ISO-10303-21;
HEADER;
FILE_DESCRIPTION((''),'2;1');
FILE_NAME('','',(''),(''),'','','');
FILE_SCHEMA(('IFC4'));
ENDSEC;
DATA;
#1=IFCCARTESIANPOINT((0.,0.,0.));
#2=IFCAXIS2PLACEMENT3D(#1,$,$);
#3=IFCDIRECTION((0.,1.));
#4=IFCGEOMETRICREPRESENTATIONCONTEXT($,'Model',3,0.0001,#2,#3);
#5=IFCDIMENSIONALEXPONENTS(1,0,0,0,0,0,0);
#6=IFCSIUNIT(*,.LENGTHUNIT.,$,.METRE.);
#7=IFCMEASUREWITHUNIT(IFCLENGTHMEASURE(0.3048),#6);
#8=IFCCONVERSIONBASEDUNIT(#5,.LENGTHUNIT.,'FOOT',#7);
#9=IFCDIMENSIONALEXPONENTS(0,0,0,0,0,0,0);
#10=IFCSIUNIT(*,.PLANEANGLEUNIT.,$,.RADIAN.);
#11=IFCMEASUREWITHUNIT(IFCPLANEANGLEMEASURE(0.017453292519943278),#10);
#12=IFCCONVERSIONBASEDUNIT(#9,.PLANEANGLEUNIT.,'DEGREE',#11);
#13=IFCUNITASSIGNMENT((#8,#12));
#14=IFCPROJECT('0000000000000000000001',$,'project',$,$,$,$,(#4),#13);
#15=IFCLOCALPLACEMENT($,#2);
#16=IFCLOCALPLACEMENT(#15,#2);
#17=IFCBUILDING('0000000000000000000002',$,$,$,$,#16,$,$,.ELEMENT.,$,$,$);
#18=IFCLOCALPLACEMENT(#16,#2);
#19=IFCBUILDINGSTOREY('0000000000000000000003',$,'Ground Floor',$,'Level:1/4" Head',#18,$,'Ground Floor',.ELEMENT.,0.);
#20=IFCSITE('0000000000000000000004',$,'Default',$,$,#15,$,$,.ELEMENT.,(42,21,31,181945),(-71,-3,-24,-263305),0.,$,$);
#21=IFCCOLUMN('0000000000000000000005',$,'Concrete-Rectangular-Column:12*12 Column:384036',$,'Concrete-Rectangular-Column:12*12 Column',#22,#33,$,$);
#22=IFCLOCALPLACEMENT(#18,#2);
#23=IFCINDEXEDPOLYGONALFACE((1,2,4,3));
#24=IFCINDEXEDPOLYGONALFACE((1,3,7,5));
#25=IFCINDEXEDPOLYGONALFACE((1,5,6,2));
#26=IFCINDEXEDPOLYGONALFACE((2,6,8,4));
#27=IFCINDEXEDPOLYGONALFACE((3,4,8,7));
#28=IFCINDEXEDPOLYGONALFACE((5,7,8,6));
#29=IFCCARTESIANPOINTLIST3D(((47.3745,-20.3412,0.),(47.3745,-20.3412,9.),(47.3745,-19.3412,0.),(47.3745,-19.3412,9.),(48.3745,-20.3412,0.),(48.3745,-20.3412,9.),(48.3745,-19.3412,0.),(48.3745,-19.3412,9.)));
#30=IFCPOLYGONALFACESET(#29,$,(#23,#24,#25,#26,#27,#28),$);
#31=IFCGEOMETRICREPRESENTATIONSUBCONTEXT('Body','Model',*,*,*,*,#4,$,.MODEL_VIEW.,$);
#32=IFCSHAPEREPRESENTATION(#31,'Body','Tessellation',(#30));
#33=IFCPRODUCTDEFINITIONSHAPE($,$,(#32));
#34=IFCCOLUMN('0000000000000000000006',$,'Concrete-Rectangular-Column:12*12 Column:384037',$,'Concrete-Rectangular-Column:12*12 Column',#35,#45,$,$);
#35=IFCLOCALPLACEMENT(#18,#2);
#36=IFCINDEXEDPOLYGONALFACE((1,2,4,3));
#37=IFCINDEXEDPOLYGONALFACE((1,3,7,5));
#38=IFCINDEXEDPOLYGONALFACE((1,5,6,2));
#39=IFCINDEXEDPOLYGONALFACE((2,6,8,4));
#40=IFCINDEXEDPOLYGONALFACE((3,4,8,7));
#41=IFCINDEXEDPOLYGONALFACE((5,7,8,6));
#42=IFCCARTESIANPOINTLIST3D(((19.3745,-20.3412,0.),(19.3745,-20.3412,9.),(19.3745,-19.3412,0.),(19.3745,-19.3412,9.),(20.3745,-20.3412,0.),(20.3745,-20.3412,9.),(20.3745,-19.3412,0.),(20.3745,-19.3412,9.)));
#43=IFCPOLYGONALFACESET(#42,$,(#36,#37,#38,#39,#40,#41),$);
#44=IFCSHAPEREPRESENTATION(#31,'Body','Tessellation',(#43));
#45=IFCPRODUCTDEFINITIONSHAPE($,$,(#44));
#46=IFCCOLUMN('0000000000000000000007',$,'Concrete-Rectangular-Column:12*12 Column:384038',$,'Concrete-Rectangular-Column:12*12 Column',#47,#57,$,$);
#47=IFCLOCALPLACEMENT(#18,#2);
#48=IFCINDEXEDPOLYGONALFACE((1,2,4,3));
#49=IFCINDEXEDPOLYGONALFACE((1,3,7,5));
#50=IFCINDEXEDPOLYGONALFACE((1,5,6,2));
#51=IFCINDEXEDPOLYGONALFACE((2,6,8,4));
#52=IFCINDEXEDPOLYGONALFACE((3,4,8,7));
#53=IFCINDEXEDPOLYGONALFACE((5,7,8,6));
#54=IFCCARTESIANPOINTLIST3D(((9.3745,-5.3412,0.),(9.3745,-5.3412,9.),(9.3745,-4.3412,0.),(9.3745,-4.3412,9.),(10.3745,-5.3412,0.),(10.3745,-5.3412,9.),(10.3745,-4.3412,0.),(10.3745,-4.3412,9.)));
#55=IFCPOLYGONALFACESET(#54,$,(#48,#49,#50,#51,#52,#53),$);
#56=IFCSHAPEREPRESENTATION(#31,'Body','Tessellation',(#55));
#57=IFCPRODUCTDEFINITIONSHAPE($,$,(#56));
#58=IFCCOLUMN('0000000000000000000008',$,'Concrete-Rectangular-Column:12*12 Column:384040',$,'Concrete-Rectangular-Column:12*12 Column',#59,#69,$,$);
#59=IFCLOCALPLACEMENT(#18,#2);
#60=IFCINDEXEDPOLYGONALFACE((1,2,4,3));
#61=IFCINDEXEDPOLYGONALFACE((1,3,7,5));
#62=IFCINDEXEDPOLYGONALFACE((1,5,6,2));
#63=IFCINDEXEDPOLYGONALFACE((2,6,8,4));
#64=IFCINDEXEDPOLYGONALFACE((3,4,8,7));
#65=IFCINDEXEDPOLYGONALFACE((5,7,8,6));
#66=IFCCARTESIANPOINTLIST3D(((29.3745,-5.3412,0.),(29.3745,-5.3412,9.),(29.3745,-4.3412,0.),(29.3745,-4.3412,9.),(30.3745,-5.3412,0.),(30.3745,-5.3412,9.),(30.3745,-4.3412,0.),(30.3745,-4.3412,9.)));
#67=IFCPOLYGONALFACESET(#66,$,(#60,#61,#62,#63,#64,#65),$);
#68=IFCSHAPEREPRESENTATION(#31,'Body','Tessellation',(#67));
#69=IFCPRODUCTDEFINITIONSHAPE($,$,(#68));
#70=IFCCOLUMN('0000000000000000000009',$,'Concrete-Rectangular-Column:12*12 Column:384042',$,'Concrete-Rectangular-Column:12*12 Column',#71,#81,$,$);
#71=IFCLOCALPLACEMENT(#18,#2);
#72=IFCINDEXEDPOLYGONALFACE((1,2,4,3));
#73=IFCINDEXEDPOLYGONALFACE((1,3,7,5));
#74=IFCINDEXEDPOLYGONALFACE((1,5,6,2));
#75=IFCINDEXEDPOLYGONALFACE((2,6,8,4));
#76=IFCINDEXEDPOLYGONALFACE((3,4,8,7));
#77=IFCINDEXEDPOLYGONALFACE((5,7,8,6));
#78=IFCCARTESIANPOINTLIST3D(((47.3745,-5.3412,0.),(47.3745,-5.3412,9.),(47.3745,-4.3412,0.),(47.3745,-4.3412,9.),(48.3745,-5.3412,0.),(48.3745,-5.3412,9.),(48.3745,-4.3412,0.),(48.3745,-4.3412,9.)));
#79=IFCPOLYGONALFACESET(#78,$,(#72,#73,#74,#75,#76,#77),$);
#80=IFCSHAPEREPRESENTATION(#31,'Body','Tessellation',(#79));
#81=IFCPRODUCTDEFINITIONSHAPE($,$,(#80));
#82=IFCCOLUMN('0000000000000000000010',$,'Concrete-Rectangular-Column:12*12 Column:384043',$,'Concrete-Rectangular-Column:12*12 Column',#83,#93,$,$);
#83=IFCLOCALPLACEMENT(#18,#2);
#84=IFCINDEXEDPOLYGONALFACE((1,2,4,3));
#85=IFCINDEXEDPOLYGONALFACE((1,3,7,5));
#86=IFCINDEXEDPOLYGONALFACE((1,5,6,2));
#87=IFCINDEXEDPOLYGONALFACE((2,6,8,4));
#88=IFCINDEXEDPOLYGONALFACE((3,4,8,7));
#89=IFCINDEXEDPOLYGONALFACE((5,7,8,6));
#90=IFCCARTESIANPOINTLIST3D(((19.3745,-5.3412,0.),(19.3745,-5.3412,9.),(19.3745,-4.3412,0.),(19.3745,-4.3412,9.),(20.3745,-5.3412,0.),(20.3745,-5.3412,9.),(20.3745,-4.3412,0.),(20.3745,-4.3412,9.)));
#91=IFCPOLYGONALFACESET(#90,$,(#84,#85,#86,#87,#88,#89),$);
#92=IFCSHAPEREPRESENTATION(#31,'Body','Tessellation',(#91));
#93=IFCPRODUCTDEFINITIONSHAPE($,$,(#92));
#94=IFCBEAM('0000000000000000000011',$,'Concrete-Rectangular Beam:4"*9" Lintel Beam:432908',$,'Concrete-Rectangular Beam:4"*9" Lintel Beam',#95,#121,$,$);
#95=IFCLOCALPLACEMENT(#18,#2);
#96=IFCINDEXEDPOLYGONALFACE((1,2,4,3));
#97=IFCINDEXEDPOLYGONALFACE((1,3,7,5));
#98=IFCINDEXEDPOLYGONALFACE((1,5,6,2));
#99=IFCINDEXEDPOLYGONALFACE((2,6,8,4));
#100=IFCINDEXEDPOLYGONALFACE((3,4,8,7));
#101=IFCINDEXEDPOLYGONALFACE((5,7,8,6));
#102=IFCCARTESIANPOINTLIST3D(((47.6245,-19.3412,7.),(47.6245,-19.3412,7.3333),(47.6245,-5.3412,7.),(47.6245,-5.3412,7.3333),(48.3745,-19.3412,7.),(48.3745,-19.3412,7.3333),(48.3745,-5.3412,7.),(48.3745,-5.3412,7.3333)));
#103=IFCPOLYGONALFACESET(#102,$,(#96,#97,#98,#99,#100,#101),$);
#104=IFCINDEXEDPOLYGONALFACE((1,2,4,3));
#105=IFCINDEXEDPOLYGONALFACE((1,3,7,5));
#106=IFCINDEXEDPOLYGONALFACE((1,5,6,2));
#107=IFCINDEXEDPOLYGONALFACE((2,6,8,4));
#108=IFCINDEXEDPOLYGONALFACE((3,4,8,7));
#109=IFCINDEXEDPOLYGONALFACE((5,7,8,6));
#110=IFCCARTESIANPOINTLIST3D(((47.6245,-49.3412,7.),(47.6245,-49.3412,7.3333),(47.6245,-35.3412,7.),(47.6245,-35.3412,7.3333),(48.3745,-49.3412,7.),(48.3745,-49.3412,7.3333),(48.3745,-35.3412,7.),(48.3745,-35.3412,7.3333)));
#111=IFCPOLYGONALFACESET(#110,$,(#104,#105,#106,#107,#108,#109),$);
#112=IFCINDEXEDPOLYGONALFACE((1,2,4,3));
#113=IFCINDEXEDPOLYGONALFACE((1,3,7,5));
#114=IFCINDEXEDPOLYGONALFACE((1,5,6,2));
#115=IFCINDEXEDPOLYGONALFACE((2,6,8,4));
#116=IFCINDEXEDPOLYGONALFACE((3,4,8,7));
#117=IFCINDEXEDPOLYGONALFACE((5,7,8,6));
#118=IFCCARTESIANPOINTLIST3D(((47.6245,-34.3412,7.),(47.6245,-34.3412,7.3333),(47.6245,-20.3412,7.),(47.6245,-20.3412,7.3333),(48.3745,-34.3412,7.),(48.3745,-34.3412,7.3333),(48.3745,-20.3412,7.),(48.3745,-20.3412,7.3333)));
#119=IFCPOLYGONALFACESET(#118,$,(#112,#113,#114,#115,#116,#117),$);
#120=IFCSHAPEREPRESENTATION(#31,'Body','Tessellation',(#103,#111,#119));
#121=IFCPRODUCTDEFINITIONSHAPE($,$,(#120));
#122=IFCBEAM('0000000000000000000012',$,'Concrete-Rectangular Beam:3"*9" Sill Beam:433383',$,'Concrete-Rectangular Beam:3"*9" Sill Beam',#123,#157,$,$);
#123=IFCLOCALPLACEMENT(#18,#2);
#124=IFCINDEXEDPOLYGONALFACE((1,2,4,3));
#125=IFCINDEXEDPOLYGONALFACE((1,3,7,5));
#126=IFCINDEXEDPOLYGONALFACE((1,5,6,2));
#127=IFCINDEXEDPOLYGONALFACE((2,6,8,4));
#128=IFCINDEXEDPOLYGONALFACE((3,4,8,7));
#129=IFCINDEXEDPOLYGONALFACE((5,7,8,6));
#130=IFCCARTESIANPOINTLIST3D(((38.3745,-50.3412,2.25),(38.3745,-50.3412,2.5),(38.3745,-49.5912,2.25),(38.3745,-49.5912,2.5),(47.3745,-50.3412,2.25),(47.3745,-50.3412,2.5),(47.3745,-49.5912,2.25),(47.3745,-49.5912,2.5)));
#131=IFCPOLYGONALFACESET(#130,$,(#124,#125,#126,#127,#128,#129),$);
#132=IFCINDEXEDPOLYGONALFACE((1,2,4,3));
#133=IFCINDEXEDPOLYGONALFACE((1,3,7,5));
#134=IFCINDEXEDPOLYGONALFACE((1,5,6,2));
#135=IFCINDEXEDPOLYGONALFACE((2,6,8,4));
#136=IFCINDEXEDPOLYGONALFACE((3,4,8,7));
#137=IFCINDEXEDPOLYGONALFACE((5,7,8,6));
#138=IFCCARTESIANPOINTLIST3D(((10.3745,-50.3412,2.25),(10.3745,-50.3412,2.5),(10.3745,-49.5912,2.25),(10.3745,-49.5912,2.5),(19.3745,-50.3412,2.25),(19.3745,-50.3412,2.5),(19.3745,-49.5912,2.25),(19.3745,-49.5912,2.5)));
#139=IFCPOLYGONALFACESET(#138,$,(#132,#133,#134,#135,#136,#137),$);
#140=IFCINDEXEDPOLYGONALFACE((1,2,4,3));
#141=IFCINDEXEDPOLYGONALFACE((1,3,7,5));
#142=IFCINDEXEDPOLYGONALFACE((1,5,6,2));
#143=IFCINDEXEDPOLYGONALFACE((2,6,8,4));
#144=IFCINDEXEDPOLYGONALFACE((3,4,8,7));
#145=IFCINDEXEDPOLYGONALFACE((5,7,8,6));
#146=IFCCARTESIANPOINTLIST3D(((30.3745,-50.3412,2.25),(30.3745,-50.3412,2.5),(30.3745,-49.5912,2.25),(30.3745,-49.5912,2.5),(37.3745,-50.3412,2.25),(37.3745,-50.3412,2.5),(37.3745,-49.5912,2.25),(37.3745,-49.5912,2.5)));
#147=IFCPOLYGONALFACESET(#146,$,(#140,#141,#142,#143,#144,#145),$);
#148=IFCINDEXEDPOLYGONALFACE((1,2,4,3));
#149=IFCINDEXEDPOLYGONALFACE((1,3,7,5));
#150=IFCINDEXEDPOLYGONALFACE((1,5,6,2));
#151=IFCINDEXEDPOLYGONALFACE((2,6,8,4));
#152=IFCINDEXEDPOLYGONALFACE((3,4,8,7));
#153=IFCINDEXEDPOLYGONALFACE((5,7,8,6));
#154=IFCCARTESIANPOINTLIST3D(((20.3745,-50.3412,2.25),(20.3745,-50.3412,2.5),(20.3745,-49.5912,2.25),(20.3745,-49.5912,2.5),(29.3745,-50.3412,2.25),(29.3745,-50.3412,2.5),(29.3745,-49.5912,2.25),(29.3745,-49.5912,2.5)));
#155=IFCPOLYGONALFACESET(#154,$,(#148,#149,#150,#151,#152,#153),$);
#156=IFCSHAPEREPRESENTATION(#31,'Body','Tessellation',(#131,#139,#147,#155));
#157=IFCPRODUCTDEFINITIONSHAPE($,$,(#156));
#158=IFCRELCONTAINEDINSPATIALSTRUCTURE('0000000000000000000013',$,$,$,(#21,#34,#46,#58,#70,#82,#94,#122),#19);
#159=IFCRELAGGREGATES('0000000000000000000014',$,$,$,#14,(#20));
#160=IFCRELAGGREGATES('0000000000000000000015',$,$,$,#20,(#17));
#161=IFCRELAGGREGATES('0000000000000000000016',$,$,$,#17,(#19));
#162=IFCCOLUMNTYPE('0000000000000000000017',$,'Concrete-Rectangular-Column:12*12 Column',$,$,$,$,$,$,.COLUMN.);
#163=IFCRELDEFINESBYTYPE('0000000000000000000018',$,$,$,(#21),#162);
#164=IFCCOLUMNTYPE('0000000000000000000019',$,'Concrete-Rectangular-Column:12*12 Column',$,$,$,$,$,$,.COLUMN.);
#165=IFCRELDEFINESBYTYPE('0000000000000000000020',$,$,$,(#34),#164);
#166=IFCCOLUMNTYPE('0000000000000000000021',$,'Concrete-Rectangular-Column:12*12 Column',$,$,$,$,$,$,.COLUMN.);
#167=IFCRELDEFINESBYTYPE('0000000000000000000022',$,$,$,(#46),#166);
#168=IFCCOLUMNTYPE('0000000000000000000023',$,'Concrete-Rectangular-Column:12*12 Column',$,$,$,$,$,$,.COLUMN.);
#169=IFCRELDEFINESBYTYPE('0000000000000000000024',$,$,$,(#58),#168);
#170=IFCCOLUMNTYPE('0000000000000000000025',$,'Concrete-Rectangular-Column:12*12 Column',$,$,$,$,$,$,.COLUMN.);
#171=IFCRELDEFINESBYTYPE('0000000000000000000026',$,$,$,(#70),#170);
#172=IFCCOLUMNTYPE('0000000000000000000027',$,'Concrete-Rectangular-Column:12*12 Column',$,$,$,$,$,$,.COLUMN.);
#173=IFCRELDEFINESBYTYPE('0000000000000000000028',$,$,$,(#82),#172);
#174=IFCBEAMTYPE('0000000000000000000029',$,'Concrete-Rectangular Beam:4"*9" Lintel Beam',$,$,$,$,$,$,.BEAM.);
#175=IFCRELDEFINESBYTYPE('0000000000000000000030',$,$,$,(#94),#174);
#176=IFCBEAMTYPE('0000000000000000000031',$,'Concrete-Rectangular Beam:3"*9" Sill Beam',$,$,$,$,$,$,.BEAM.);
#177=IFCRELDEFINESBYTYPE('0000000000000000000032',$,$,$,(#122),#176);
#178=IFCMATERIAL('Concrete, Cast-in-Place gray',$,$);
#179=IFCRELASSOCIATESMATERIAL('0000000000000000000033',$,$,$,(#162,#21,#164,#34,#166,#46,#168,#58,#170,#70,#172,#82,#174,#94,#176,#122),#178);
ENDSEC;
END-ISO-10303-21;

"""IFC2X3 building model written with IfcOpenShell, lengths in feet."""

from ifc_helpers import new_model, entity, si_unit, converted_unit, direction, frame, frame_2d, origin, origin_2d_with_axis, place, context, subcontext, project, spatial, rectangle, extrude, source, transform, mapped, material, type_object, type_shapes, element, save


model = new_model("IFC2X3")

# Units and contexts
model_context = context("Model", 3, precision=0.0001, world=origin(), true_north=direction((0.0, 1.0)))
body_context = subcontext(model_context, "Body", "Model", "MODEL_VIEW")
ifc_project = project(units=[converted_unit("LENGTHUNIT", "FOOT", entity("IfcLengthMeasure", 0.3048), si_unit("LENGTHUNIT", "METRE"), dimensions=[1, 0, 0, 0, 0, 0, 0]), converted_unit("PLANEANGLEUNIT", "DEGREE", entity("IfcPlaneAngleMeasure", 0.017453292519943278), si_unit("PLANEANGLEUNIT", "RADIAN"), dimensions=[0, 0, 0, 0, 0, 0, 0])], contexts=[model_context])

# Site, building, storey
site_placement = place(None, origin())
site = spatial("IfcSite", under=ifc_project, at=site_placement, Name="Default", CompositionType="ELEMENT", RefLatitude=(42, 21, 31, 181945), RefLongitude=(-71, -3, -24, -263305), RefElevation=0.0)
building_placement = place(site_placement, origin())
building = spatial("IfcBuilding", under=site, at=building_placement, CompositionType="ELEMENT")
storey_placement = place(building_placement, origin())
storey = spatial("IfcBuildingStorey", under=building, at=storey_placement, Name="Ground Floor", ObjectType="Level:1/4\" Head", LongName="Ground Floor", CompositionType="ELEMENT", Elevation=0.0)

# Columns
ifc_material_1 = material(Name="Concrete, Cast-in-Place gray")
column_type_1 = type_object("IfcColumnType", Name="Concrete-Rectangular-Column:12*12 Column", PredefinedType="COLUMN", material=ifc_material_1)
shared_shape_1 = source(origin(), body_context, "Body", "SweptSolid", [
    extrude(rectangle(XDim=1.0, YDim=1.0, at=frame_2d((0.0, 0.0), x_axis=(1.0, 0.0))), frame((47.8745, -19.8412, 0.0), z_axis=(0.0, 0.0, 1.0), x_axis=(-1.0, 0.0, 0.0)), (0.0, 0.0, 1.0), 9.0),
])
type_shapes(column_type_1, [shared_shape_1])
column_1_placement = place(storey_placement, origin())
element("IfcColumn", 1, at=column_1_placement, inside=storey, type_object=column_type_1, material=ifc_material_1, Name="Concrete-Rectangular-Column:12*12 Column:384036", ObjectType="Concrete-Rectangular-Column:12*12 Column", context=body_context, shape_type="MappedRepresentation", body=[
    mapped(shared_shape_1, transform((0.0, 0.0, 0.0), scale=1.0)),
])
column_type_2 = type_object("IfcColumnType", Name="Concrete-Rectangular-Column:12*12 Column", PredefinedType="COLUMN", material=ifc_material_1)
shared_shape_2 = source(origin(), body_context, "Body", "SweptSolid", [
    extrude(rectangle(XDim=1.0, YDim=1.0, at=frame_2d((0.0, 0.0), x_axis=(1.0, 0.0))), frame((19.8745, -19.8412, 0.0), z_axis=(0.0, 0.0, 1.0), x_axis=(-1.0, 0.0, 0.0)), (0.0, 0.0, 1.0), 9.0),
])
type_shapes(column_type_2, [shared_shape_2])
column_2_placement = place(storey_placement, origin())
element("IfcColumn", 2, at=column_2_placement, inside=storey, type_object=column_type_2, material=ifc_material_1, Name="Concrete-Rectangular-Column:12*12 Column:384037", ObjectType="Concrete-Rectangular-Column:12*12 Column", context=body_context, shape_type="MappedRepresentation", body=[
    mapped(shared_shape_2, transform((0.0, 0.0, 0.0), scale=1.0)),
])
column_type_3 = type_object("IfcColumnType", Name="Concrete-Rectangular-Column:12*12 Column", PredefinedType="COLUMN", material=ifc_material_1)
shared_shape_3 = source(origin(), body_context, "Body", "SweptSolid", [
    extrude(rectangle(XDim=1.0, YDim=1.0, at=origin_2d_with_axis()), frame((9.8745, -4.8412, 0.0), z_axis=(0.0, 0.0, 1.0), x_axis=(-1.0, 0.0, 0.0)), (0.0, 0.0, 1.0), 9.0),
])
type_shapes(column_type_3, [shared_shape_3])
column_3_placement = place(storey_placement, origin())
element("IfcColumn", 3, at=column_3_placement, inside=storey, type_object=column_type_3, material=ifc_material_1, Name="Concrete-Rectangular-Column:12*12 Column:384038", ObjectType="Concrete-Rectangular-Column:12*12 Column", context=body_context, shape_type="MappedRepresentation", body=[
    mapped(shared_shape_3, transform((0.0, 0.0, 0.0), scale=1.0)),
])
column_type_4 = type_object("IfcColumnType", Name="Concrete-Rectangular-Column:12*12 Column", PredefinedType="COLUMN", material=ifc_material_1)
shared_shape_4 = source(origin(), body_context, "Body", "SweptSolid", [
    extrude(rectangle(XDim=1.0, YDim=1.0, at=frame_2d((0.0, 0.0), x_axis=(1.0, 0.0))), frame((29.8745, -4.8412, 0.0), z_axis=(0.0, 0.0, 1.0), x_axis=(-1.0, 0.0, 0.0)), (0.0, 0.0, 1.0), 9.0),
])
type_shapes(column_type_4, [shared_shape_4])
column_4_placement = place(storey_placement, origin())
element("IfcColumn", 4, at=column_4_placement, inside=storey, type_object=column_type_4, material=ifc_material_1, Name="Concrete-Rectangular-Column:12*12 Column:384040", ObjectType="Concrete-Rectangular-Column:12*12 Column", context=body_context, shape_type="MappedRepresentation", body=[
    mapped(shared_shape_4, transform((0.0, 0.0, 0.0), scale=1.0)),
])
column_type_5 = type_object("IfcColumnType", Name="Concrete-Rectangular-Column:12*12 Column", PredefinedType="COLUMN", material=ifc_material_1)
shared_shape_5 = source(origin(), body_context, "Body", "SweptSolid", [
    extrude(rectangle(XDim=1.0, YDim=1.0, at=frame_2d((0.0, 0.0), x_axis=(1.0, 0.0))), frame((47.8745, -4.8412, 0.0), z_axis=(0.0, 0.0, 1.0), x_axis=(-1.0, 0.0, 0.0)), (0.0, 0.0, 1.0), 9.0),
])
type_shapes(column_type_5, [shared_shape_5])
column_5_placement = place(storey_placement, origin())
element("IfcColumn", 5, at=column_5_placement, inside=storey, type_object=column_type_5, material=ifc_material_1, Name="Concrete-Rectangular-Column:12*12 Column:384042", ObjectType="Concrete-Rectangular-Column:12*12 Column", context=body_context, shape_type="MappedRepresentation", body=[
    mapped(shared_shape_5, transform((0.0, 0.0, 0.0), scale=1.0)),
])
column_type_6 = type_object("IfcColumnType", Name="Concrete-Rectangular-Column:12*12 Column", PredefinedType="COLUMN", material=ifc_material_1)
shared_shape_6 = source(origin(), body_context, "Body", "SweptSolid", [
    extrude(rectangle(XDim=1.0, YDim=1.0, at=frame_2d((0.0, 0.0), x_axis=(1.0, 0.0))), frame((19.8745, -4.8412, 0.0), z_axis=(0.0, 0.0, 1.0), x_axis=(-1.0, 0.0, 0.0)), (0.0, 0.0, 1.0), 9.0),
])
type_shapes(column_type_6, [shared_shape_6])
column_6_placement = place(storey_placement, origin())
element("IfcColumn", 6, at=column_6_placement, inside=storey, type_object=column_type_6, material=ifc_material_1, Name="Concrete-Rectangular-Column:12*12 Column:384043", ObjectType="Concrete-Rectangular-Column:12*12 Column", context=body_context, shape_type="MappedRepresentation", body=[
    mapped(shared_shape_6, transform((0.0, 0.0, 0.0), scale=1.0)),
])

# Beams
beam_type_1 = type_object("IfcBeamType", Name="Concrete-Rectangular Beam:4\"*9\" Lintel Beam", PredefinedType="BEAM", material=ifc_material_1)
shared_shape_7 = source(origin(), body_context, "Body", "SweptSolid", [
    extrude(rectangle(XDim=0.3333, YDim=0.75, at=frame_2d((0.0, 0.0), x_axis=(0.0, 1.0))), frame((47.9995, -19.3412, 7.1667), z_axis=(0.0, 1.0, 0.0), x_axis=(-1.0, 0.0, 0.0)), (0.0, 0.0, 1.0), 14.0),
    extrude(rectangle(XDim=0.3333, YDim=0.75, at=frame_2d((0.0, 0.0), x_axis=(0.0, 1.0))), frame((47.9995, -49.3412, 7.1667), z_axis=(0.0, 1.0, 0.0), x_axis=(-1.0, 0.0, 0.0)), (0.0, 0.0, 1.0), 14.0),
    extrude(rectangle(XDim=0.3333, YDim=0.75, at=frame_2d((0.0, 0.0), x_axis=(0.0, 1.0))), frame((47.9995, -34.3412, 7.1667), z_axis=(0.0, 1.0, 0.0), x_axis=(-1.0, 0.0, 0.0)), (0.0, 0.0, 1.0), 14.0),
])
type_shapes(beam_type_1, [shared_shape_7])
beam_1_placement = place(storey_placement, origin())
element("IfcBeam", 7, at=beam_1_placement, inside=storey, type_object=beam_type_1, material=ifc_material_1, Name="Concrete-Rectangular Beam:4\"*9\" Lintel Beam:432908", ObjectType="Concrete-Rectangular Beam:4\"*9\" Lintel Beam", context=body_context, shape_type="MappedRepresentation", body=[
    mapped(shared_shape_7, transform((0.0, 0.0, 0.0), scale=1.0)),
])
beam_type_2 = type_object("IfcBeamType", Name="Concrete-Rectangular Beam:3\"*9\" Sill Beam", PredefinedType="BEAM", material=ifc_material_1)
shared_shape_8 = source(origin(), body_context, "Body", "SweptSolid", [
    extrude(rectangle(XDim=0.25, YDim=0.75, at=frame_2d((0.0, 0.0), x_axis=(1.0, 0.0))), frame((38.3745, -49.9662, 2.375), z_axis=(1.0, 0.0, 0.0), x_axis=(0.0, 0.0, -1.0)), (0.0, 0.0, 1.0), 9.0),
    extrude(rectangle(XDim=0.25, YDim=0.75, at=frame_2d((0.0, 0.0), x_axis=(1.0, 0.0))), frame((10.3745, -49.9662, 2.375), z_axis=(1.0, 0.0, 0.0), x_axis=(0.0, 0.0, -1.0)), (0.0, 0.0, 1.0), 9.0),
    extrude(rectangle(XDim=0.25, YDim=0.75, at=frame_2d((0.0, 0.0), x_axis=(1.0, 0.0))), frame((30.3745, -49.9662, 2.375), z_axis=(1.0, 0.0, 0.0), x_axis=(0.0, 0.0, -1.0)), (0.0, 0.0, 1.0), 7.0),
    extrude(rectangle(XDim=0.25, YDim=0.75, at=frame_2d((0.0, 0.0), x_axis=(1.0, 0.0))), frame((20.3745, -49.9662, 2.375), z_axis=(1.0, 0.0, 0.0), x_axis=(0.0, 0.0, -1.0)), (0.0, 0.0, 1.0), 9.0),
])
type_shapes(beam_type_2, [shared_shape_8])
beam_2_placement = place(storey_placement, origin())
element("IfcBeam", 8, at=beam_2_placement, inside=storey, type_object=beam_type_2, material=ifc_material_1, Name="Concrete-Rectangular Beam:3\"*9\" Sill Beam:433383", ObjectType="Concrete-Rectangular Beam:3\"*9\" Sill Beam", context=body_context, shape_type="MappedRepresentation", body=[
    mapped(shared_shape_8, transform((0.0, 0.0, 0.0), scale=1.0)),
])

save(model, "model.ifc")
